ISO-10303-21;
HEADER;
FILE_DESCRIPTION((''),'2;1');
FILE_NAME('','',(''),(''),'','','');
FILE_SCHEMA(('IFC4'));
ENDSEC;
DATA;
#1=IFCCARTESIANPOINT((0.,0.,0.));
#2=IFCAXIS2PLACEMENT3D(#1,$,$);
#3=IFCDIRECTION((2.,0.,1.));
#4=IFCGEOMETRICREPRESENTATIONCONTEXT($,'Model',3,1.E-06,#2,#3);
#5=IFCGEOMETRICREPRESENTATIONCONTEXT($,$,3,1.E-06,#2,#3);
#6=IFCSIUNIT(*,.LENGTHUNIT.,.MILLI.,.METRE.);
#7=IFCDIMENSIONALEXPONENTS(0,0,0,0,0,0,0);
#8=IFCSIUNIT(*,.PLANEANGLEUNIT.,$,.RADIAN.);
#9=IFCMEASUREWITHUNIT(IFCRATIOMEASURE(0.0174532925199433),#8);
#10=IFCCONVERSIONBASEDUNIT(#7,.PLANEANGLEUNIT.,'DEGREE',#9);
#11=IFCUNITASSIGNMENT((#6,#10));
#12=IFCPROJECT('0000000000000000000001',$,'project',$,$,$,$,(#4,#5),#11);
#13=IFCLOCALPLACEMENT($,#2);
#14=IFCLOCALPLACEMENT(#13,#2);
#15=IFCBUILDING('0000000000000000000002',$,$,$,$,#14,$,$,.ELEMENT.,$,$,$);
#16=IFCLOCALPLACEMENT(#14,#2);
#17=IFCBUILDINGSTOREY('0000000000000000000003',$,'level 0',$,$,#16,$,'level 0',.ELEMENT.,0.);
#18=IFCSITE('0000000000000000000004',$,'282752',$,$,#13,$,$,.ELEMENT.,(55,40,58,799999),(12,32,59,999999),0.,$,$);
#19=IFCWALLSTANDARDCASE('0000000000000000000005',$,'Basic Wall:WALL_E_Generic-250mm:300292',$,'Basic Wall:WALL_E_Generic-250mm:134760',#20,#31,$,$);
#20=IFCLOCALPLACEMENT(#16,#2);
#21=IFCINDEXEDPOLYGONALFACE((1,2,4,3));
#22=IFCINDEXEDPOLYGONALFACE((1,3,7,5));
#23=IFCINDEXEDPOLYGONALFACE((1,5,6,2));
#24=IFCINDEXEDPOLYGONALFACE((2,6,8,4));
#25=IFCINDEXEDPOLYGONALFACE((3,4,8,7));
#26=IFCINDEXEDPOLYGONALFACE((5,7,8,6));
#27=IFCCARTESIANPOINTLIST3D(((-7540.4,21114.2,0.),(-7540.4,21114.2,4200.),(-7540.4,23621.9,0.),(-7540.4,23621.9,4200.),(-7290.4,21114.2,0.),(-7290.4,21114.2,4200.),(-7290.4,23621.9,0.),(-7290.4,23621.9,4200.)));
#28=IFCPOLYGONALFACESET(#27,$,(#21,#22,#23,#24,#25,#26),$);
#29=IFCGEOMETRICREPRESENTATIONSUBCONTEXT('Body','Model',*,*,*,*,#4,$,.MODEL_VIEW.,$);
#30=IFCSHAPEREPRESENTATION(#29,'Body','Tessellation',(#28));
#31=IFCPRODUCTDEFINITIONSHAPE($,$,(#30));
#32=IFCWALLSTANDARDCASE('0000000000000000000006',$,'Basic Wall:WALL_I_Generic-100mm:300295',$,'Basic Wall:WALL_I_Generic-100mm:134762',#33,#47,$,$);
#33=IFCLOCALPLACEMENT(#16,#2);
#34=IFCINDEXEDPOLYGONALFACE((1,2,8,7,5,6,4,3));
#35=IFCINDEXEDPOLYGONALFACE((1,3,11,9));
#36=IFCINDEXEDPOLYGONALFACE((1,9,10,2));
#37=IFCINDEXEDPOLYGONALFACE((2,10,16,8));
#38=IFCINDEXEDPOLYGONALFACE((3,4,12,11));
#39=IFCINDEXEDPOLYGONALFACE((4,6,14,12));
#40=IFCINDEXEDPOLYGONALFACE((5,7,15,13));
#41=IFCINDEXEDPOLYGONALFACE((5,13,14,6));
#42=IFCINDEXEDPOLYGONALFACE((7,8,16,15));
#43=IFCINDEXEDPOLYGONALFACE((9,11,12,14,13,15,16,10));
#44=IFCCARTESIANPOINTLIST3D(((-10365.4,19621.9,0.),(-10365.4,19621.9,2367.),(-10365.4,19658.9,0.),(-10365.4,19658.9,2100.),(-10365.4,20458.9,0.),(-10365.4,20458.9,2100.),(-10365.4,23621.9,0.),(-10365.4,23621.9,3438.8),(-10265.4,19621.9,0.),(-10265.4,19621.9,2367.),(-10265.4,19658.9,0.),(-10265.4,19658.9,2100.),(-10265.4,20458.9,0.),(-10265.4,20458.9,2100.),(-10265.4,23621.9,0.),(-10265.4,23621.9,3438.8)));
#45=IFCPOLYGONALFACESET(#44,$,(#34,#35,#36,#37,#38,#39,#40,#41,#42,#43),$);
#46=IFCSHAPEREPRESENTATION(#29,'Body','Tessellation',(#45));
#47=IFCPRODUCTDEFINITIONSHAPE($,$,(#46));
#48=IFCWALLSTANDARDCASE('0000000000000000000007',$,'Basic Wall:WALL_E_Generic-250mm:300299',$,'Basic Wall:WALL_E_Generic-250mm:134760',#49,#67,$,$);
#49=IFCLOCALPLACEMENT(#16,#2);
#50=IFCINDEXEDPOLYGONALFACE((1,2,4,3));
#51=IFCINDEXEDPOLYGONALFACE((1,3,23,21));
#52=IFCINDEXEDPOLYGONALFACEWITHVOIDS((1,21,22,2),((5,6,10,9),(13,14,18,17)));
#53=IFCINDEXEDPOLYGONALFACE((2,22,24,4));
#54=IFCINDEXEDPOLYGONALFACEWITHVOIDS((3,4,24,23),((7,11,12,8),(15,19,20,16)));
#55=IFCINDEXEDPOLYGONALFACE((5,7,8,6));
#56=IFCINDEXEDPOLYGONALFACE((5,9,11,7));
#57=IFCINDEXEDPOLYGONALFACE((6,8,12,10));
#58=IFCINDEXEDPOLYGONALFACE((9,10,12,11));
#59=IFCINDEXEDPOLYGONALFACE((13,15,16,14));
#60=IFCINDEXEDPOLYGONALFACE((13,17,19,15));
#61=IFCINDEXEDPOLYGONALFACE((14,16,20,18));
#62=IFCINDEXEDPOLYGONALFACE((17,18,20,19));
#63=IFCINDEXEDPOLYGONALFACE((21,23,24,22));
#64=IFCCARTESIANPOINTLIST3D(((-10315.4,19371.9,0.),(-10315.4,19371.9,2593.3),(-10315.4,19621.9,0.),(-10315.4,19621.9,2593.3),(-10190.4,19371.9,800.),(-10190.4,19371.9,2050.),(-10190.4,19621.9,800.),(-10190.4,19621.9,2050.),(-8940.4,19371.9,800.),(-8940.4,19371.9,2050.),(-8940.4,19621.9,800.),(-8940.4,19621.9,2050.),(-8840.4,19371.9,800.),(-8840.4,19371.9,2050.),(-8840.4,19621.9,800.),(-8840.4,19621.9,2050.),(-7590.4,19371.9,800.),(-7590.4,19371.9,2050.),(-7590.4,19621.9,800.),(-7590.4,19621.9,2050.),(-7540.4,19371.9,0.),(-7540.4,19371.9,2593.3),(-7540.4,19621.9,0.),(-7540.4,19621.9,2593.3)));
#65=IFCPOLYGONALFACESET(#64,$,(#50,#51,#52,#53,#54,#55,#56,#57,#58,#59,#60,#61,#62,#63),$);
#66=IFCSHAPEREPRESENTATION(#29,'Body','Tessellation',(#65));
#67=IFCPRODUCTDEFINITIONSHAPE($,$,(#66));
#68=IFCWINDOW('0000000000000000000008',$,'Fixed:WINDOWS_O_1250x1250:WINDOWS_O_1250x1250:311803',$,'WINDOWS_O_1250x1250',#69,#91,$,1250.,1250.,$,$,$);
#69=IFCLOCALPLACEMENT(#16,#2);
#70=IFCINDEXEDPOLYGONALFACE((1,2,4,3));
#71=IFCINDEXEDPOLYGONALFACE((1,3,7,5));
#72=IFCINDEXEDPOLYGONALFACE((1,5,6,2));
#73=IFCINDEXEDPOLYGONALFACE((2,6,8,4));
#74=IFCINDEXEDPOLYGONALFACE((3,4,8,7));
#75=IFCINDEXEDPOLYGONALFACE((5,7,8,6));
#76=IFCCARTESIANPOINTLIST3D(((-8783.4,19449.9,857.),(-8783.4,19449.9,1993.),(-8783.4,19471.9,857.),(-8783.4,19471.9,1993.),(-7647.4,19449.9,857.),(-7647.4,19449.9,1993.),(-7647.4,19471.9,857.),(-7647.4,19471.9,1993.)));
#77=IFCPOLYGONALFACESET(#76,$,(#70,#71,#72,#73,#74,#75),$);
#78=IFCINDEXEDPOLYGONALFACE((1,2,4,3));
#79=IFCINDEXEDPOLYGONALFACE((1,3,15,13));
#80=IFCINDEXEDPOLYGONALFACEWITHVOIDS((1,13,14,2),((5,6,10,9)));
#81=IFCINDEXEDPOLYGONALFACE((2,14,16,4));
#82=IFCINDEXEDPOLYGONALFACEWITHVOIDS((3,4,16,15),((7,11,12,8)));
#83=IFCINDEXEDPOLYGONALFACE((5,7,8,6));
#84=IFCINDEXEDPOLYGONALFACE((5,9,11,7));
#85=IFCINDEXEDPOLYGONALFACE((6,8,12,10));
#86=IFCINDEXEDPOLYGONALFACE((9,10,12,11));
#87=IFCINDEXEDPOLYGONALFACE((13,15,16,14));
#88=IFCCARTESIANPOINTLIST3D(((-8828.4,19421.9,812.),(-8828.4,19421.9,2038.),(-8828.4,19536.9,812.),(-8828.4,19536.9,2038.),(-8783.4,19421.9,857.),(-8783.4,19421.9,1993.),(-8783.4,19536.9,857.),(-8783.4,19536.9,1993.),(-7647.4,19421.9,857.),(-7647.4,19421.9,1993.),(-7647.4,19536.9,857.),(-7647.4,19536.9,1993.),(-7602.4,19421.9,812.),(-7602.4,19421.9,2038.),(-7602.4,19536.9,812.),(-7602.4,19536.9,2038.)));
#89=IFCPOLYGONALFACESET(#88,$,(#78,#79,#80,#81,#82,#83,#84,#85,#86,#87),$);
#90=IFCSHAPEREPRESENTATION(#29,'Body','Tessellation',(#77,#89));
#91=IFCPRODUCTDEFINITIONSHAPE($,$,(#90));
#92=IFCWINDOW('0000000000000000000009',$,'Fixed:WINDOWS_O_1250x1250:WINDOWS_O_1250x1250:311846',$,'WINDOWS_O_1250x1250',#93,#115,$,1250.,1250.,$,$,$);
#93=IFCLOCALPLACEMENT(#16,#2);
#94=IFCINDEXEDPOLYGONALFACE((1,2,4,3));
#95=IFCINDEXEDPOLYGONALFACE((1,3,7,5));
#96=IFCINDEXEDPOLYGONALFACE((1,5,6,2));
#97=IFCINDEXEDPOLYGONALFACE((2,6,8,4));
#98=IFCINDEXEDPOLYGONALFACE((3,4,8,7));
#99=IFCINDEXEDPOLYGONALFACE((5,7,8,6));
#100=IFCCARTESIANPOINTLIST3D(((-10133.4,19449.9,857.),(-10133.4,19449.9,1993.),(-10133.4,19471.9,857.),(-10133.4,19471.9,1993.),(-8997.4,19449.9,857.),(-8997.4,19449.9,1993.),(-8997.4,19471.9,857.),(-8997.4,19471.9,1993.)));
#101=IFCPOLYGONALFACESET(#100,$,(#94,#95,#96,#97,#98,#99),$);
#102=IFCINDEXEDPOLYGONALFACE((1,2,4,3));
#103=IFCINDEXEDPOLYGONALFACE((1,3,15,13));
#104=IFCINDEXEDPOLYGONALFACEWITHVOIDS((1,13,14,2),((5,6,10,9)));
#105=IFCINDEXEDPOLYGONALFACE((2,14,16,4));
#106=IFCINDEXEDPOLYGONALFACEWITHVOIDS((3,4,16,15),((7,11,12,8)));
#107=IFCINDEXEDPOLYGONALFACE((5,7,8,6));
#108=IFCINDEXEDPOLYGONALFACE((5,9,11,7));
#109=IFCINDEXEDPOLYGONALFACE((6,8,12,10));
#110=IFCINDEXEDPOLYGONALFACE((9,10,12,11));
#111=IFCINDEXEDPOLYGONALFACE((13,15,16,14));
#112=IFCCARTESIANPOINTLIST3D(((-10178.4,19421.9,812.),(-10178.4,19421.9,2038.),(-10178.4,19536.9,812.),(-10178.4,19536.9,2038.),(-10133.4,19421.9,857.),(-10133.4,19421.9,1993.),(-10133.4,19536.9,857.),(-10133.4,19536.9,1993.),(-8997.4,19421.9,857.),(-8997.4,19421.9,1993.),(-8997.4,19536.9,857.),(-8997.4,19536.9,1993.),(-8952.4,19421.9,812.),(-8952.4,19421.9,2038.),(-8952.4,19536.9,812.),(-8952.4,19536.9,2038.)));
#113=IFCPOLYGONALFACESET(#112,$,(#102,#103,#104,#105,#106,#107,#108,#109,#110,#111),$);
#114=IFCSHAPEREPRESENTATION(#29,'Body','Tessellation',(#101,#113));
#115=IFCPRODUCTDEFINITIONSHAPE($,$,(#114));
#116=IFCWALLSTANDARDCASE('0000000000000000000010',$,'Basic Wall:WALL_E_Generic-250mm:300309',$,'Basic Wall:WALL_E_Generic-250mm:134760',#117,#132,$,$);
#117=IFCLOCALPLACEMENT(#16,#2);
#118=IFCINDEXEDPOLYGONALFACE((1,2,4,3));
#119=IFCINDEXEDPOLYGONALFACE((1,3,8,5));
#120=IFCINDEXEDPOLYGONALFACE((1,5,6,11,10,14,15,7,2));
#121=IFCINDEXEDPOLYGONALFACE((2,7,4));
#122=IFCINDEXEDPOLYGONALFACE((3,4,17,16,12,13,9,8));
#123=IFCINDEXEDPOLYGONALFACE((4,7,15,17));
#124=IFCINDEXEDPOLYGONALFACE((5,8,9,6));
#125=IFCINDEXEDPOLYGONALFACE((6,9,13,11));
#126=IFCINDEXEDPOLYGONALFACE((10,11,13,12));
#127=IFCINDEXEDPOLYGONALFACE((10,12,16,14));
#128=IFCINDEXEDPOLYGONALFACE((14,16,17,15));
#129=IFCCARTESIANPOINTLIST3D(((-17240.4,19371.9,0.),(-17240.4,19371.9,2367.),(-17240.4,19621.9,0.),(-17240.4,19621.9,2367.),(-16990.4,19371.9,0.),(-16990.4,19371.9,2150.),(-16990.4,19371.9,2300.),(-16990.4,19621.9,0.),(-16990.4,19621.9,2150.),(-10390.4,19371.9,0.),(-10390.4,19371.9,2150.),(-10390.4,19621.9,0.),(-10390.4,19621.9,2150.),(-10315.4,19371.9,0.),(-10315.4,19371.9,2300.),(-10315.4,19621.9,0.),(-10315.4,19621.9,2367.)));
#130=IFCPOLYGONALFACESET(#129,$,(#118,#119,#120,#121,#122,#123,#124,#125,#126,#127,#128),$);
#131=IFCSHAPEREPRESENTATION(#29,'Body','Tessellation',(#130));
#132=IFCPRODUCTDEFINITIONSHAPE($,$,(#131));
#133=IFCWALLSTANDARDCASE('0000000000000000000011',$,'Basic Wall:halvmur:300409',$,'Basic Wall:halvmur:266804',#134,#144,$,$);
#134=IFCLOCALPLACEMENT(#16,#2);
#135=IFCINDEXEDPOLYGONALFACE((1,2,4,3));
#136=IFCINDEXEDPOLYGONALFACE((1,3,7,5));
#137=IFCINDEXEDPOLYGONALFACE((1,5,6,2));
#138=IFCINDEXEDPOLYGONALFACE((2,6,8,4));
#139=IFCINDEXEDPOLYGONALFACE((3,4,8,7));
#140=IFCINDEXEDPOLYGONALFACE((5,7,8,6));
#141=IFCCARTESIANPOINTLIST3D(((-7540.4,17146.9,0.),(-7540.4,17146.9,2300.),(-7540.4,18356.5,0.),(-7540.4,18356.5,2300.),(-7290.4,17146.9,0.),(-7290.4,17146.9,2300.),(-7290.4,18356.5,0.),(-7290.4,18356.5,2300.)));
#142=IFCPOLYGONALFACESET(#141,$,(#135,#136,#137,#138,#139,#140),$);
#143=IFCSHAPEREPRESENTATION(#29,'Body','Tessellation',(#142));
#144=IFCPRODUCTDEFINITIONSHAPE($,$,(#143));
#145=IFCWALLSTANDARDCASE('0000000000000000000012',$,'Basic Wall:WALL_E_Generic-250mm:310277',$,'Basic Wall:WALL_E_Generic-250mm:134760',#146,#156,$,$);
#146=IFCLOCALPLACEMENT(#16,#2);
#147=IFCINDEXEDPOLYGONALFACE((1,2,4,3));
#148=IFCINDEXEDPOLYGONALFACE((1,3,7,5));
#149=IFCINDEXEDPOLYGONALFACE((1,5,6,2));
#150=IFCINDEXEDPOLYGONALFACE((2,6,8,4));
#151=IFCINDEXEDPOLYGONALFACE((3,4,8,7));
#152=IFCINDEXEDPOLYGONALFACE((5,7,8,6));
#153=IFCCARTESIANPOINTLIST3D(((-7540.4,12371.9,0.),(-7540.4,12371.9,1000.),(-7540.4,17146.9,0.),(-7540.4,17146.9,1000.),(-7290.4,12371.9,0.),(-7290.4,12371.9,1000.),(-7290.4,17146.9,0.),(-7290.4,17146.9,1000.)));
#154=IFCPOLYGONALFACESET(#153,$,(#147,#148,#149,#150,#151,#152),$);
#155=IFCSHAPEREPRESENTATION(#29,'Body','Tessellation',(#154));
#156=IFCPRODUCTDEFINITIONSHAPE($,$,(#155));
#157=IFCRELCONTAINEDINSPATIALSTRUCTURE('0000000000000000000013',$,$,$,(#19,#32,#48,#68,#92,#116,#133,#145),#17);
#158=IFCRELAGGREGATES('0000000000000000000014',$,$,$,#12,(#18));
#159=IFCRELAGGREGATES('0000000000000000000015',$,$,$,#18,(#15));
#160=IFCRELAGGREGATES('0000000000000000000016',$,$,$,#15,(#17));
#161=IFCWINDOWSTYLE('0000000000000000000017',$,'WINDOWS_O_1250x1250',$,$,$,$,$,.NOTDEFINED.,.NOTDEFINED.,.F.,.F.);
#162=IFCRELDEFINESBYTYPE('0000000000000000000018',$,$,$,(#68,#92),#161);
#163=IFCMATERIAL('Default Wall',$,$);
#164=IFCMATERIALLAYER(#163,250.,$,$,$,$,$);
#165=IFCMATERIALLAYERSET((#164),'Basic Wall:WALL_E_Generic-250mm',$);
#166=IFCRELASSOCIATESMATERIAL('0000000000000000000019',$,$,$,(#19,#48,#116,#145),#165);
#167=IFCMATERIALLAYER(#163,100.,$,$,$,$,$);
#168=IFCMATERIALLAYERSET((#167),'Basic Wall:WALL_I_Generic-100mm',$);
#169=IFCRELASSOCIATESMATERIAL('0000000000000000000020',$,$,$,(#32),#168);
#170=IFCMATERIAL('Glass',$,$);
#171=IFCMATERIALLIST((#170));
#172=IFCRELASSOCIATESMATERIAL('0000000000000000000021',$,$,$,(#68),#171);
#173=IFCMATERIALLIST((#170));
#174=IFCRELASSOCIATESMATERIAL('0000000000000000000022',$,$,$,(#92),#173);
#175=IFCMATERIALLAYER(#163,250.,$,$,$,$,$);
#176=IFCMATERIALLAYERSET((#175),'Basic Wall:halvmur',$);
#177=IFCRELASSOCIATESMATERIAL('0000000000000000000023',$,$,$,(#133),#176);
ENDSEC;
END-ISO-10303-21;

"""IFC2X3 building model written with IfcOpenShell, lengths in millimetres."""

from ifc_helpers import new_model, entity, si_unit, converted_unit, direction, frame, frame_2d, origin, origin_2d_with_axis, place, context, subcontext, project, spatial, polyline, rectangle, outline, extrude, clip, bounded_halfspace, source, transform, mapped, material, material_list, layer, layer_set, layer_usage, type_object, type_shapes, element, fill, save


model = new_model("IFC2X3")

# Units and contexts
model_context = context("Model", 3, precision=1e-06, world=origin(), true_north=direction((2.0, 0.0, 1.0)))
context_of_model = context(None, 3, precision=1e-06, world=origin(), true_north=direction((2.0, 0.0, 1.0)))
body_context = subcontext(model_context, "Body", "Model", "MODEL_VIEW")
ifc_project = project(units=[si_unit("LENGTHUNIT", "METRE", prefix="MILLI"), converted_unit("PLANEANGLEUNIT", "DEGREE", entity("IfcRatioMeasure", 0.0174532925199433), si_unit("PLANEANGLEUNIT", "RADIAN"), dimensions=[0, 0, 0, 0, 0, 0, 0])], contexts=[model_context, context_of_model])

# Site, building, storey
site_placement = place(None, origin())
site = spatial("IfcSite", under=ifc_project, at=site_placement, Name="282752", CompositionType="ELEMENT", RefLatitude=(55, 40, 58, 799999), RefLongitude=(12, 32, 59, 999999), RefElevation=0.0)
building_placement = place(site_placement, origin())
building = spatial("IfcBuilding", under=site, at=building_placement, CompositionType="ELEMENT")
storey_placement = place(building_placement, origin())
storey = spatial("IfcBuildingStorey", under=building, at=storey_placement, Name="level 0", LongName="level 0", CompositionType="ELEMENT", Elevation=0.0)

# Shared definitions
ifc_material_1 = material(Name="Glass")

# Wall
ifc_material_2 = material(Name="Default Wall")
ifc_layer_1 = layer(ifc_material_2, 250.0)
ifc_layer_set_1 = layer_set([ifc_layer_1], Name="Basic Wall:WALL_E_Generic-250mm")
ifc_layer_usage_1 = layer_usage(ifc_layer_set_1, "AXIS2", "NEGATIVE", 125.0)
wall_1_placement = place(storey_placement, frame((-7415.4, 23621.9, 0.0), z_axis=(0.0, 0.0, 1.0), x_axis=(0.0, -1.0, 0.0)))
element("IfcWallStandardCase", 1, at=wall_1_placement, inside=storey, material=ifc_layer_usage_1, Name="Basic Wall:WALL_E_Generic-250mm:300292", ObjectType="Basic Wall:WALL_E_Generic-250mm:134760", context=body_context, shape_type="SweptSolid", body=[
    extrude(rectangle(XDim=2507.7, YDim=250.0, at=frame_2d((1253.8, 0.0), x_axis=(-1.0, 0.0))), origin(), (0.0, 0.0, 1.0), 4200.0),
])

# Wall, opening
ifc_layer_2 = layer(ifc_material_2, 100.0)
ifc_layer_set_2 = layer_set([ifc_layer_2], Name="Basic Wall:WALL_I_Generic-100mm")
ifc_layer_usage_2 = layer_usage(ifc_layer_set_2, "AXIS2", "NEGATIVE", 50.0)
wall_2_placement = place(storey_placement, frame((-10315.4, 23621.9, 0.0), z_axis=(0.0, 0.0, 1.0), x_axis=(0.0, -1.0, 0.0)))
wall_2 = element("IfcWallStandardCase", 2, at=wall_2_placement, inside=storey, material=ifc_layer_usage_2, Name="Basic Wall:WALL_I_Generic-100mm:300295", ObjectType="Basic Wall:WALL_I_Generic-100mm:134762", context=body_context, shape_type="Clipping", body=[
    clip(extrude(rectangle(XDim=4000.0, YDim=100.0, at=frame_2d((2000.0, 0.0), x_axis=(-1.0, 0.0))), origin(), (0.0, 0.0, 1.0), 3438.8), bounded_halfspace(frame((0.0, -50.0, 3438.8), z_axis=(0.258819, 0.0, 0.965926), x_axis=(0.0, 1.0, 0.0)), False, frame((0.0, -50.0, 3438.8)), polyline([(0.0, 0.0), (4000.0, 0.0), (4000.0, 50.0), (4000.0, 100.0), (0.0, 100.0), (0.0, 0.0)]))),
])
opening_1_placement = place(wall_2_placement, frame((3163.0, -50.0, 0.0)))
element("IfcOpeningElement", 3, at=opening_1_placement, cuts=wall_2, ObjectType="Opening", context=body_context, shape_type="SweptSolid", body=[
    extrude(rectangle(XDim=2100.0, YDim=800.0, at=frame_2d((1050.0, 400.0), x_axis=(1.0, 0.0))), frame((0.0, 0.0, 0.0), z_axis=(0.0, 1.0, 0.0), x_axis=(0.0, 0.0, 1.0)), (0.0, 0.0, 1.0), 100.0),
])

# Wall, openings, windows
ifc_layer_usage_3 = layer_usage(ifc_layer_set_1, "AXIS2", "NEGATIVE", 125.0)
wall_3_placement = place(storey_placement, frame((-10315.4, 19496.9, 0.0)))
wall_3 = element("IfcWallStandardCase", 4, at=wall_3_placement, inside=storey, material=ifc_layer_usage_3, Name="Basic Wall:WALL_E_Generic-250mm:300299", ObjectType="Basic Wall:WALL_E_Generic-250mm:134760", context=body_context, shape_type="SweptSolid", body=[
    extrude(rectangle(XDim=2775.0, YDim=250.0, at=frame_2d((1387.5, 0.0), x_axis=(-1.0, 0.0))), origin(), (0.0, 0.0, 1.0), 2593.3),
])
opening_2_placement = place(wall_3_placement, frame((1475.0, -125.0, 800.0)))
opening_2 = element("IfcOpeningElement", 5, at=opening_2_placement, cuts=wall_3, ObjectType="Opening", context=body_context, shape_type="SweptSolid", body=[
    extrude(rectangle(XDim=1250.0, YDim=1250.0, at=frame_2d((625.0, 625.0), x_axis=(1.0, 0.0))), frame((0.0, 0.0, 0.0), z_axis=(0.0, 1.0, 0.0), x_axis=(0.0, 0.0, 1.0)), (0.0, 0.0, 1.0), 250.0),
])
opening_3_placement = place(wall_3_placement, frame((125.0, -125.0, 800.0)))
opening_3 = element("IfcOpeningElement", 6, at=opening_3_placement, cuts=wall_3, ObjectType="Opening", context=body_context, shape_type="SweptSolid", body=[
    extrude(rectangle(XDim=1250.0, YDim=1250.0, at=frame_2d((625.0, 625.0), x_axis=(1.0, 0.0))), frame((0.0, 0.0, 0.0), z_axis=(0.0, 1.0, 0.0), x_axis=(0.0, 0.0, 1.0)), (0.0, 0.0, 1.0), 250.0),
])
ifc_material_list_1 = material_list([ifc_material_1])
window_style = type_object("IfcWindowStyle", Name="WINDOWS_O_1250x1250", ConstructionType="NOTDEFINED", OperationType="NOTDEFINED", ParameterTakesPrecedence=False, Sizeable=False)
shared_shape_1 = source(origin(), body_context, "Body", "SweptSolid", [
    extrude(rectangle(XDim=1136.0, YDim=22.0, at=origin_2d_with_axis()), frame((625.0, 161.0, 57.0), z_axis=(0.0, 0.0, 1.0), x_axis=(-1.0, 0.0, 0.0)), (0.0, 0.0, 1.0), 1136.0),
    extrude(outline(polyline([(-613.0, -613.0), (613.0, -613.0), (613.0, 613.0), (-613.0, 613.0), (-613.0, -613.0)]), holes=[polyline([(568.0, -568.0), (-568.0, -568.0), (-568.0, 568.0), (568.0, 568.0), (568.0, -568.0)])]), frame((625.0, 85.0, 625.0), z_axis=(0.0, 1.0, 0.0), x_axis=(0.0, 0.0, 1.0)), (0.0, 0.0, 1.0), 115.0),
])
type_shapes(window_style, [shared_shape_1])
window_1_placement = place(opening_2_placement, frame((1250.0, 250.0, 0.0), z_axis=(0.0, 0.0, 1.0), x_axis=(-1.0, 0.0, 0.0)))
window_1 = element("IfcWindow", 7, at=window_1_placement, inside=storey, type_object=window_style, material=ifc_material_list_1, Name="Fixed:WINDOWS_O_1250x1250:WINDOWS_O_1250x1250:311803", ObjectType="WINDOWS_O_1250x1250", OverallHeight=1250.0, OverallWidth=1250.0, context=body_context, shape_type="MappedRepresentation", body=[
    mapped(shared_shape_1, transform((0.0, 0.0, 0.0), scale=1.0)),
])
fill(opening_2, window_1)
ifc_material_list_2 = material_list([ifc_material_1])
window_2_placement = place(opening_3_placement, frame((1250.0, 250.0, 0.0), z_axis=(0.0, 0.0, 1.0), x_axis=(-1.0, 0.0, 0.0)))
window_2 = element("IfcWindow", 8, at=window_2_placement, inside=storey, type_object=window_style, material=ifc_material_list_2, Name="Fixed:WINDOWS_O_1250x1250:WINDOWS_O_1250x1250:311846", ObjectType="WINDOWS_O_1250x1250", OverallHeight=1250.0, OverallWidth=1250.0, context=body_context, shape_type="MappedRepresentation", body=[
    mapped(shared_shape_1, transform((0.0, 0.0, 0.0), scale=1.0)),
])
fill(opening_3, window_2)

# Wall, opening
ifc_layer_usage_4 = layer_usage(ifc_layer_set_1, "AXIS2", "NEGATIVE", 125.0)
wall_4_placement = place(storey_placement, frame((-10315.4, 19496.9, 0.0), z_axis=(0.0, 0.0, 1.0), x_axis=(-1.0, 0.0, 0.0)))
wall_4 = element("IfcWallStandardCase", 9, at=wall_4_placement, inside=storey, material=ifc_layer_usage_4, Name="Basic Wall:WALL_E_Generic-250mm:300309", ObjectType="Basic Wall:WALL_E_Generic-250mm:134760", context=body_context, shape_type="Clipping", body=[
    clip(clip(extrude(rectangle(XDim=6925.0, YDim=250.0, at=frame_2d((3462.5, 0.0), x_axis=(-1.0, 0.0))), origin(), (0.0, 0.0, 1.0), 2593.3), bounded_halfspace(frame((6925.0, 125.0, 2367.0), z_axis=(-0.258819, 0.0, 0.965926), x_axis=(0.0, -1.0, 0.0)), False, frame((6925.0, 125.0, 2367.0)), polyline([(0.0, 0.0), (-250.0, 0.0), (0.0, -250.0), (0.0, 0.0)]))), bounded_halfspace(frame((0.0, 125.0, 2300.0), z_axis=(0.0, 0.258819, 0.965926), x_axis=(-1.0, 0.0, 0.0)), False, frame((0.0, 125.0, 2300.0)), polyline([(0.0, 0.0), (0.0, -250.0), (50.0, -250.0), (6750.0, -250.0), (6850.0, -250.0), (6925.0, -250.0), (6675.0, 0.0), (0.0, 0.0)]))),
])
opening_4_placement = place(wall_4_placement, origin())
element("IfcOpeningElement", 10, at=opening_4_placement, cuts=wall_4, ObjectType="Opening", context=body_context, shape_type="SweptSolid", body=[
    extrude(rectangle(XDim=2150.0, YDim=6600.0, at=origin_2d_with_axis()), frame((3375.0, -277.4, 1075.0), z_axis=(0.0, 1.0, 0.0), x_axis=(0.0, 0.0, 1.0)), (0.0, 0.0, 1.0), 554.8),
])

# Walls
ifc_layer_3 = layer(ifc_material_2, 250.0)
ifc_layer_set_3 = layer_set([ifc_layer_3], Name="Basic Wall:halvmur")
ifc_layer_usage_5 = layer_usage(ifc_layer_set_3, "AXIS2", "NEGATIVE", 125.0)
wall_5_placement = place(storey_placement, frame((-7415.4, 18356.5, 0.0), z_axis=(0.0, 0.0, 1.0), x_axis=(0.0, -1.0, 0.0)))
element("IfcWallStandardCase", 11, at=wall_5_placement, inside=storey, material=ifc_layer_usage_5, Name="Basic Wall:halvmur:300409", ObjectType="Basic Wall:halvmur:266804", context=body_context, shape_type="SweptSolid", body=[
    extrude(rectangle(XDim=1209.7, YDim=250.0, at=frame_2d((604.8, 0.0), x_axis=(-1.0, 0.0))), origin(), (0.0, 0.0, 1.0), 2300.0),
])
ifc_layer_usage_6 = layer_usage(ifc_layer_set_1, "AXIS2", "NEGATIVE", 125.0)
wall_6_placement = place(storey_placement, frame((-7415.4, 17146.9, 0.0), z_axis=(0.0, 0.0, 1.0), x_axis=(0.0, -1.0, 0.0)))
element("IfcWallStandardCase", 12, at=wall_6_placement, inside=storey, material=ifc_layer_usage_6, Name="Basic Wall:WALL_E_Generic-250mm:310277", ObjectType="Basic Wall:WALL_E_Generic-250mm:134760", context=body_context, shape_type="SweptSolid", body=[
    extrude(rectangle(XDim=4775.0, YDim=250.0, at=frame_2d((2387.5, 0.0), x_axis=(-1.0, 0.0))), origin(), (0.0, 0.0, 1.0), 1000.0),
])

save(model, "model.ifc")
